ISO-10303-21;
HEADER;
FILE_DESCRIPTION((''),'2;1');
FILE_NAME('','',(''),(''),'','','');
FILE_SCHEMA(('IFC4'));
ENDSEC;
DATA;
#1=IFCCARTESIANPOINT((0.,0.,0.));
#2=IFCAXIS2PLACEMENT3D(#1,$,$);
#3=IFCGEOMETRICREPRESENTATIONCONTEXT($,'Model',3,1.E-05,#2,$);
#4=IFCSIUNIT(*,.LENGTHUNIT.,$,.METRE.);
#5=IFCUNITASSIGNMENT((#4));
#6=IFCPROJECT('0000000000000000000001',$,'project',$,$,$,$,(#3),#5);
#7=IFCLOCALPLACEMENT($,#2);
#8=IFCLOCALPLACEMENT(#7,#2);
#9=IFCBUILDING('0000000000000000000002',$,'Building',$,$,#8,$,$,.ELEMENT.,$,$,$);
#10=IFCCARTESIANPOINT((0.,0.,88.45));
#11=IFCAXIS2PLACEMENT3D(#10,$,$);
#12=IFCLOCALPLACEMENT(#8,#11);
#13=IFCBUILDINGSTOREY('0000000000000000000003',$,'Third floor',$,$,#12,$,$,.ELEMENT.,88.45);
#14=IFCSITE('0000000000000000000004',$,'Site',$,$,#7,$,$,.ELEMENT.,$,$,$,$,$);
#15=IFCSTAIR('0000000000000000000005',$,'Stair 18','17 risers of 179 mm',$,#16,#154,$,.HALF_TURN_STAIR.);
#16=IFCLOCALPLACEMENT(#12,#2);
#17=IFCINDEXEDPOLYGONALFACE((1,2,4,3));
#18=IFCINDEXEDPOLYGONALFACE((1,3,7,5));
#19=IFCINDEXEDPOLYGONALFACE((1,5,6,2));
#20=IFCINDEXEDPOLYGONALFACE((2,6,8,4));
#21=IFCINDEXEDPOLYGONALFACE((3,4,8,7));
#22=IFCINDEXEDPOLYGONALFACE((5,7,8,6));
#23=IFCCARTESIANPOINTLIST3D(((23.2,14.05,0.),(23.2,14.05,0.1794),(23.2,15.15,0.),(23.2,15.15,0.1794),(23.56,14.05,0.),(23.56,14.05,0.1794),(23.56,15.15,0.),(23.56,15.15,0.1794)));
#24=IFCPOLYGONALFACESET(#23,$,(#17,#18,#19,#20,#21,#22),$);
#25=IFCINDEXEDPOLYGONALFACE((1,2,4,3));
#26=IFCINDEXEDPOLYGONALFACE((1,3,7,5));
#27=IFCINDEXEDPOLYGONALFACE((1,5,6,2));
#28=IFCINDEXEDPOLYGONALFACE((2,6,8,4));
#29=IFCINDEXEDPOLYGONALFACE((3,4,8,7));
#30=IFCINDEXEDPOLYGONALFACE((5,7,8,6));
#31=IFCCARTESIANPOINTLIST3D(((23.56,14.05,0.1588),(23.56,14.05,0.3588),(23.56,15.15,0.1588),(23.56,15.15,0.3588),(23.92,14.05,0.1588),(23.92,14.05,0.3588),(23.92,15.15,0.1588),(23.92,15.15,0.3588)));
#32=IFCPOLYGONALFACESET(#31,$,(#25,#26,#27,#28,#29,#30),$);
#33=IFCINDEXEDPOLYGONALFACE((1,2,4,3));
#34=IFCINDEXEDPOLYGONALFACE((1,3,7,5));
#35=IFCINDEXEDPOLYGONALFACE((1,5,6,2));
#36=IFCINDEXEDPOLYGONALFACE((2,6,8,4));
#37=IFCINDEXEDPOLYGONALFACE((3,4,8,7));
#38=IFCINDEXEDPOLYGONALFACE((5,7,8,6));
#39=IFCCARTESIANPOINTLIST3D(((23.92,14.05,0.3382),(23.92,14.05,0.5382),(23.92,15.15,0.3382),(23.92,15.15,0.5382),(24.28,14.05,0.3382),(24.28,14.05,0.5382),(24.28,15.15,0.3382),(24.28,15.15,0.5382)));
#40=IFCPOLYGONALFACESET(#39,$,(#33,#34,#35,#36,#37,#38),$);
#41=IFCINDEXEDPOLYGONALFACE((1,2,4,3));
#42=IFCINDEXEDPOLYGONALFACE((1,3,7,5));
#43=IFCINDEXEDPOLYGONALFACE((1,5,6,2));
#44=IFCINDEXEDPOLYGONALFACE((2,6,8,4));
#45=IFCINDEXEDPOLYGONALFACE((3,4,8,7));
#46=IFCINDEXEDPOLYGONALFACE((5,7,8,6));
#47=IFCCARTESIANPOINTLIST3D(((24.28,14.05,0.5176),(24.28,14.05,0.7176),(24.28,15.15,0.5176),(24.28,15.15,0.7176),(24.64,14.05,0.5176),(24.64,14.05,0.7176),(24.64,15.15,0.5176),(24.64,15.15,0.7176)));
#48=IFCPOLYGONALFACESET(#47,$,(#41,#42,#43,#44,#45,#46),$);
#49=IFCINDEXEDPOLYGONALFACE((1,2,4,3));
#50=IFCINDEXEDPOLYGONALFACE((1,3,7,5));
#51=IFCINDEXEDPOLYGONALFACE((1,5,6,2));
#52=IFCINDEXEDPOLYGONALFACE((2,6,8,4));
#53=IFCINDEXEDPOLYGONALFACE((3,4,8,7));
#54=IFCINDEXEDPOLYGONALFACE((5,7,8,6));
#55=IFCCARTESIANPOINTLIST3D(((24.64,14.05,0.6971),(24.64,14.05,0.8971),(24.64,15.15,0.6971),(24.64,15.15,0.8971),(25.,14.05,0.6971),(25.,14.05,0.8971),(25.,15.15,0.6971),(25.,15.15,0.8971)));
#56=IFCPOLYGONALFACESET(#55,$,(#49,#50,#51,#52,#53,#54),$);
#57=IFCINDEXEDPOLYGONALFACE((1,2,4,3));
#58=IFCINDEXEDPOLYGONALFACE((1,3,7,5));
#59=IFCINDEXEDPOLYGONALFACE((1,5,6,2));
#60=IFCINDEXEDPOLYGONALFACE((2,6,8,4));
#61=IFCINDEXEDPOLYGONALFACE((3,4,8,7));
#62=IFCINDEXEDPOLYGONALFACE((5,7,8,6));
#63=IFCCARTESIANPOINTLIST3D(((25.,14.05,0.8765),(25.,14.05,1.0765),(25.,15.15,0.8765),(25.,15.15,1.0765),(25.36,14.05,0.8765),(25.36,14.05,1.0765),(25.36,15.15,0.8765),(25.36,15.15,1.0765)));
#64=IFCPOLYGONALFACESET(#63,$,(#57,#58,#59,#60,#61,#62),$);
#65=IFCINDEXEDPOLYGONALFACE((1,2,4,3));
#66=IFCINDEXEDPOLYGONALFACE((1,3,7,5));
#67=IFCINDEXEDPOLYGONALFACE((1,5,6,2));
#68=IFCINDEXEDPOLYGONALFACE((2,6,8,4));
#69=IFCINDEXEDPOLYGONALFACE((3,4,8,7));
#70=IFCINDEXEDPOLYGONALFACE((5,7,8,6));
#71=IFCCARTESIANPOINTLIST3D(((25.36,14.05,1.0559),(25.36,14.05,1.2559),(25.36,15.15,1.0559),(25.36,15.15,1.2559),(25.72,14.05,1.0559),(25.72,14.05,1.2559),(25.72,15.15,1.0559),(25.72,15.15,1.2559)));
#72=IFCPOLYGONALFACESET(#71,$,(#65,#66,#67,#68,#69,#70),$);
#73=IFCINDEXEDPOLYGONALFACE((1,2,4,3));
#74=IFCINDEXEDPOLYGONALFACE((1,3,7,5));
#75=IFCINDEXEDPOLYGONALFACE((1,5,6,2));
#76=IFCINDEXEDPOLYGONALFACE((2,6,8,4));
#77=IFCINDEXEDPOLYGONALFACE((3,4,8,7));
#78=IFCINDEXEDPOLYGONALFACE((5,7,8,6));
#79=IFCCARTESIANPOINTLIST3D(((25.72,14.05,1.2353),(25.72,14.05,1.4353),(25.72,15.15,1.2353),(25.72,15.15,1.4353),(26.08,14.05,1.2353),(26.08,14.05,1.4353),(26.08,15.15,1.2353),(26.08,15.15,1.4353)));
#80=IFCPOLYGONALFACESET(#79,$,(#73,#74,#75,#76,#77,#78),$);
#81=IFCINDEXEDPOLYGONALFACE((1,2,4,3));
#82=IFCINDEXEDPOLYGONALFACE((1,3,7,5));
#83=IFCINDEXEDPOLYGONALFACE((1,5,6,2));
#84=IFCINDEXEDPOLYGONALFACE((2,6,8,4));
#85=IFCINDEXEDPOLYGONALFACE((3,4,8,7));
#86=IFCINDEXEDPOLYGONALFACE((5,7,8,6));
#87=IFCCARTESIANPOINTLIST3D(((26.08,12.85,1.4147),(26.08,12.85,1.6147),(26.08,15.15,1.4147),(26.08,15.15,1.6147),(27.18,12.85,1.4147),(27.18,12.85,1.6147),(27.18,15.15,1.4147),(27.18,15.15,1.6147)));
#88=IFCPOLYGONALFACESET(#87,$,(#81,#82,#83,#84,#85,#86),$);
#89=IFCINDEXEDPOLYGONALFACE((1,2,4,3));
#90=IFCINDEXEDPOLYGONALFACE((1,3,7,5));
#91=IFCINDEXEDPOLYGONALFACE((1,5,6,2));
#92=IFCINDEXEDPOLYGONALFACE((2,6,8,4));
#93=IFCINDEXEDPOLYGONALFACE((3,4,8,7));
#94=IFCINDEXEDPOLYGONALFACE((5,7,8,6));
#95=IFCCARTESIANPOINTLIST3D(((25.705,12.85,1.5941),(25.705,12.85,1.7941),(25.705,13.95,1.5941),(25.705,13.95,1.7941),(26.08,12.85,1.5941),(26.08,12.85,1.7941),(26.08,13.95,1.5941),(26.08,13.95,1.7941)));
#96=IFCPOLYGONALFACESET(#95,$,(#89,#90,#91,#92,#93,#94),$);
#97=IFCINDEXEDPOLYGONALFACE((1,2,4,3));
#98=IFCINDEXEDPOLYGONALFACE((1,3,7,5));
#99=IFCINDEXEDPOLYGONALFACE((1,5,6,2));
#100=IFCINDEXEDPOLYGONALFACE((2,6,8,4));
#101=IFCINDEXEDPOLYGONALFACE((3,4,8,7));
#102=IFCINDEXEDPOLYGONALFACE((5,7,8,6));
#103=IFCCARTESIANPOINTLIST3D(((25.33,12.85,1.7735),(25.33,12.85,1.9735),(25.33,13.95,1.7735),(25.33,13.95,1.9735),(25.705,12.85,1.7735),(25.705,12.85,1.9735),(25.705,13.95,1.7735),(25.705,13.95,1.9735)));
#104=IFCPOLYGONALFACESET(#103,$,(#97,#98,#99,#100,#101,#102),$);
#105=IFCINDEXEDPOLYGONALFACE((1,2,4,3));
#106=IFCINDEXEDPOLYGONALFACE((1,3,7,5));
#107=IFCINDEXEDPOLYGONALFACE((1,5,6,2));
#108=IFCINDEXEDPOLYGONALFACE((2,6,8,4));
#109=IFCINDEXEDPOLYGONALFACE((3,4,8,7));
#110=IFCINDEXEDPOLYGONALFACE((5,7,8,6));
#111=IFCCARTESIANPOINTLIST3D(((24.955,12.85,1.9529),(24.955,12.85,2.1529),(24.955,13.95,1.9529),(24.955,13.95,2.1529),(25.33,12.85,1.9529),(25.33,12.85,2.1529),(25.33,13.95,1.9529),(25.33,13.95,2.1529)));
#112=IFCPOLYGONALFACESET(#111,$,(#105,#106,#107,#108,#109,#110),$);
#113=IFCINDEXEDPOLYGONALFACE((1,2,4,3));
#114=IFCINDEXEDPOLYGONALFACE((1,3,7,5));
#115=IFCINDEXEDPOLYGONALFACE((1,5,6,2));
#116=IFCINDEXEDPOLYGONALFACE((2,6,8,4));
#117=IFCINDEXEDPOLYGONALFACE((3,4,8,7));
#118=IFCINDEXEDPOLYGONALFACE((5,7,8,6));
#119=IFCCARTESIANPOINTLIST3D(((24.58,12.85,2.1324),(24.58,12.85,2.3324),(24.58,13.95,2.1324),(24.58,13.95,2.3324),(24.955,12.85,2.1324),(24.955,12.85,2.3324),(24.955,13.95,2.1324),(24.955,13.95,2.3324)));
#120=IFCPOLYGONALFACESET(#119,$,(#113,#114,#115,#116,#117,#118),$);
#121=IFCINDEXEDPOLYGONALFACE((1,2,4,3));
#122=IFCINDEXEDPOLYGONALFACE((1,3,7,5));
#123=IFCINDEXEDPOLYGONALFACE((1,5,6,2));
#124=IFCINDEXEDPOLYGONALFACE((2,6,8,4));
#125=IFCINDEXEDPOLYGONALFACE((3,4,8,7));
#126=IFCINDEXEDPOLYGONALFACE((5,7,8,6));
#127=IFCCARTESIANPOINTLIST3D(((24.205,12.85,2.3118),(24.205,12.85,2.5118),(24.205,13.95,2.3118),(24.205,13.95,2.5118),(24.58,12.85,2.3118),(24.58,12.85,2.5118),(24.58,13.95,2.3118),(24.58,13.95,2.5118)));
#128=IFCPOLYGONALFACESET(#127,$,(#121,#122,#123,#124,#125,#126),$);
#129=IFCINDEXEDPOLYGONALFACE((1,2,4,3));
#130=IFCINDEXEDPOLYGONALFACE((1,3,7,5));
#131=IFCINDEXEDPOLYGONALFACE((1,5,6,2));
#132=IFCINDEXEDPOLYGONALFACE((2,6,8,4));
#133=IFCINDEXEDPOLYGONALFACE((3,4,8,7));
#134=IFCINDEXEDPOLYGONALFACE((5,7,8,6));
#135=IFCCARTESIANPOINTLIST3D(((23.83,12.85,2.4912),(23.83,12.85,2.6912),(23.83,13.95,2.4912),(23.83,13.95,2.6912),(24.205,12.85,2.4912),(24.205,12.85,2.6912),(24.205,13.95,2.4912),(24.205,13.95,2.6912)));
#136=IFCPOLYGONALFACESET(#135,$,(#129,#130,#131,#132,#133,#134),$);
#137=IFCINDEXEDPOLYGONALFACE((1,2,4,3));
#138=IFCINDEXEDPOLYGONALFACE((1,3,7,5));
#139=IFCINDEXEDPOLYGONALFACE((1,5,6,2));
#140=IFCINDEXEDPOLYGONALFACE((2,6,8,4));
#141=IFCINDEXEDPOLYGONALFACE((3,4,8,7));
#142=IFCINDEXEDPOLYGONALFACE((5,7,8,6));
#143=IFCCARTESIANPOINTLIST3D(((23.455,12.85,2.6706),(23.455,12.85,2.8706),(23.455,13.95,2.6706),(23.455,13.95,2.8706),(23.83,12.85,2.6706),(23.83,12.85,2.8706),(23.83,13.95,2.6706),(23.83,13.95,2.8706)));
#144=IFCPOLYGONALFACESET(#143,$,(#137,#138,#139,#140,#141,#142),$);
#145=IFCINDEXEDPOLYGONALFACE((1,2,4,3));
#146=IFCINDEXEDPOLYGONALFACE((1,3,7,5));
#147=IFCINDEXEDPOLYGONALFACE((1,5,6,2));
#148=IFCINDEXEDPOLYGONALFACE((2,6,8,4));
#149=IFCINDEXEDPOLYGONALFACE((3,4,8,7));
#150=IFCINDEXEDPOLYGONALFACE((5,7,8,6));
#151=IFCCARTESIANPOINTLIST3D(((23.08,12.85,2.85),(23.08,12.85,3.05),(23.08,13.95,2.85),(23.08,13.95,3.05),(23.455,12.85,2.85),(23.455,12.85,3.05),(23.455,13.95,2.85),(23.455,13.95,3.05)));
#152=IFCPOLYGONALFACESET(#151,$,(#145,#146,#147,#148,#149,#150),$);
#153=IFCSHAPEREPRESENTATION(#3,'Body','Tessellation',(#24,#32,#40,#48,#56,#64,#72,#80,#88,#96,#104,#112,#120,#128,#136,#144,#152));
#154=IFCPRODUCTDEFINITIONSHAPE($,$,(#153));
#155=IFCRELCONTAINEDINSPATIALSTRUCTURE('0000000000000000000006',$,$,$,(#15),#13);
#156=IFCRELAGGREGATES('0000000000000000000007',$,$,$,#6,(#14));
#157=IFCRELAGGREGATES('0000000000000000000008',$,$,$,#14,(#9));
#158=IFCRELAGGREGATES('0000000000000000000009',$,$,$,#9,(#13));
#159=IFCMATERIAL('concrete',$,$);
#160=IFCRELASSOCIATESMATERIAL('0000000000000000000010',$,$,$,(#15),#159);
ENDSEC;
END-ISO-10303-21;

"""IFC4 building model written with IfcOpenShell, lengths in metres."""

from ifc_helpers import new_model, si_unit, frame, origin, place, context, project, spatial, polyline, outline, extrude, material, element, save


model = new_model("IFC4")

# Units and contexts
model_context = context("Model", 3, precision=1e-05, world=origin())
ifc_project = project(units=[si_unit("LENGTHUNIT", "METRE")], contexts=[model_context])

# Site, building, storey
site_placement = place(None, origin())
site = spatial("IfcSite", under=ifc_project, at=site_placement, Name="Site", CompositionType="ELEMENT")
building_placement = place(site_placement, origin())
building = spatial("IfcBuilding", under=site, at=building_placement, Name="Building", CompositionType="ELEMENT")
storey_placement = place(building_placement, frame((0.0, 0.0, 88.45)))
storey = spatial("IfcBuildingStorey", under=building, at=storey_placement, Name="Third floor", CompositionType="ELEMENT", Elevation=88.45)

# Shared definitions
ifc_material = material(Name="concrete")

# Stair
stair_placement = place(storey_placement, frame((23.2, 14.6, 0.0), z_axis=(0.0, 0.0, 1.0), x_axis=(1.0, 0.0, 0.0)))
element("IfcStair", 1, at=stair_placement, inside=storey, material=ifc_material, Name="Stair 18", Description="17 risers of 179 mm", PredefinedType="HALF_TURN_STAIR", context=model_context, shape_type="SweptSolid", body=[
    extrude(outline(polyline([(0.0, -0.55), (0.36, -0.55), (0.36, 0.55), (0.0, 0.55), (0.0, -0.55)])), origin(), (0.0, 0.0, 1.0), 0.1794),
    extrude(outline(polyline([(0.36, -0.55), (0.72, -0.55), (0.72, 0.55), (0.36, 0.55), (0.36, -0.55)])), frame((0.0, 0.0, 0.1588)), (0.0, 0.0, 1.0), 0.2),
    extrude(outline(polyline([(0.72, -0.55), (1.08, -0.55), (1.08, 0.55), (0.72, 0.55), (0.72, -0.55)])), frame((0.0, 0.0, 0.3382)), (0.0, 0.0, 1.0), 0.2),
    extrude(outline(polyline([(1.08, -0.55), (1.44, -0.55), (1.44, 0.55), (1.08, 0.55), (1.08, -0.55)])), frame((0.0, 0.0, 0.5176)), (0.0, 0.0, 1.0), 0.2),
    extrude(outline(polyline([(1.44, -0.55), (1.8, -0.55), (1.8, 0.55), (1.44, 0.55), (1.44, -0.55)])), frame((0.0, 0.0, 0.6971)), (0.0, 0.0, 1.0), 0.2),
    extrude(outline(polyline([(1.8, -0.55), (2.16, -0.55), (2.16, 0.55), (1.8, 0.55), (1.8, -0.55)])), frame((0.0, 0.0, 0.8765)), (0.0, 0.0, 1.0), 0.2),
    extrude(outline(polyline([(2.16, -0.55), (2.52, -0.55), (2.52, 0.55), (2.16, 0.55), (2.16, -0.55)])), frame((0.0, 0.0, 1.0559)), (0.0, 0.0, 1.0), 0.2),
    extrude(outline(polyline([(2.52, -0.55), (2.88, -0.55), (2.88, 0.55), (2.52, 0.55), (2.52, -0.55)])), frame((0.0, 0.0, 1.2353)), (0.0, 0.0, 1.0), 0.2),
    extrude(outline(polyline([(2.88, -1.75), (3.98, -1.75), (3.98, 0.55), (2.88, 0.55), (2.88, -1.75)])), frame((0.0, 0.0, 1.4147)), (0.0, 0.0, 1.0), 0.2),
    extrude(outline(polyline([(2.505, -1.75), (2.88, -1.75), (2.88, -0.65), (2.505, -0.65), (2.505, -1.75)])), frame((0.0, 0.0, 1.5941)), (0.0, 0.0, 1.0), 0.2),
    extrude(outline(polyline([(2.13, -1.75), (2.505, -1.75), (2.505, -0.65), (2.13, -0.65), (2.13, -1.75)])), frame((0.0, 0.0, 1.7735)), (0.0, 0.0, 1.0), 0.2),
    extrude(outline(polyline([(1.755, -1.75), (2.13, -1.75), (2.13, -0.65), (1.755, -0.65), (1.755, -1.75)])), frame((0.0, 0.0, 1.9529)), (0.0, 0.0, 1.0), 0.2),
    extrude(outline(polyline([(1.38, -1.75), (1.755, -1.75), (1.755, -0.65), (1.38, -0.65), (1.38, -1.75)])), frame((0.0, 0.0, 2.1324)), (0.0, 0.0, 1.0), 0.2),
    extrude(outline(polyline([(1.005, -1.75), (1.38, -1.75), (1.38, -0.65), (1.005, -0.65), (1.005, -1.75)])), frame((0.0, 0.0, 2.3118)), (0.0, 0.0, 1.0), 0.2),
    extrude(outline(polyline([(0.63, -1.75), (1.005, -1.75), (1.005, -0.65), (0.63, -0.65), (0.63, -1.75)])), frame((0.0, 0.0, 2.4912)), (0.0, 0.0, 1.0), 0.2),
    extrude(outline(polyline([(0.255, -1.75), (0.63, -1.75), (0.63, -0.65), (0.255, -0.65), (0.255, -1.75)])), frame((0.0, 0.0, 2.6706)), (0.0, 0.0, 1.0), 0.2),
    extrude(outline(polyline([(-0.12, -1.75), (0.255, -1.75), (0.255, -0.65), (-0.12, -0.65), (-0.12, -1.75)])), frame((0.0, 0.0, 2.85)), (0.0, 0.0, 1.0), 0.2),
])

save(model, "model.ifc")
